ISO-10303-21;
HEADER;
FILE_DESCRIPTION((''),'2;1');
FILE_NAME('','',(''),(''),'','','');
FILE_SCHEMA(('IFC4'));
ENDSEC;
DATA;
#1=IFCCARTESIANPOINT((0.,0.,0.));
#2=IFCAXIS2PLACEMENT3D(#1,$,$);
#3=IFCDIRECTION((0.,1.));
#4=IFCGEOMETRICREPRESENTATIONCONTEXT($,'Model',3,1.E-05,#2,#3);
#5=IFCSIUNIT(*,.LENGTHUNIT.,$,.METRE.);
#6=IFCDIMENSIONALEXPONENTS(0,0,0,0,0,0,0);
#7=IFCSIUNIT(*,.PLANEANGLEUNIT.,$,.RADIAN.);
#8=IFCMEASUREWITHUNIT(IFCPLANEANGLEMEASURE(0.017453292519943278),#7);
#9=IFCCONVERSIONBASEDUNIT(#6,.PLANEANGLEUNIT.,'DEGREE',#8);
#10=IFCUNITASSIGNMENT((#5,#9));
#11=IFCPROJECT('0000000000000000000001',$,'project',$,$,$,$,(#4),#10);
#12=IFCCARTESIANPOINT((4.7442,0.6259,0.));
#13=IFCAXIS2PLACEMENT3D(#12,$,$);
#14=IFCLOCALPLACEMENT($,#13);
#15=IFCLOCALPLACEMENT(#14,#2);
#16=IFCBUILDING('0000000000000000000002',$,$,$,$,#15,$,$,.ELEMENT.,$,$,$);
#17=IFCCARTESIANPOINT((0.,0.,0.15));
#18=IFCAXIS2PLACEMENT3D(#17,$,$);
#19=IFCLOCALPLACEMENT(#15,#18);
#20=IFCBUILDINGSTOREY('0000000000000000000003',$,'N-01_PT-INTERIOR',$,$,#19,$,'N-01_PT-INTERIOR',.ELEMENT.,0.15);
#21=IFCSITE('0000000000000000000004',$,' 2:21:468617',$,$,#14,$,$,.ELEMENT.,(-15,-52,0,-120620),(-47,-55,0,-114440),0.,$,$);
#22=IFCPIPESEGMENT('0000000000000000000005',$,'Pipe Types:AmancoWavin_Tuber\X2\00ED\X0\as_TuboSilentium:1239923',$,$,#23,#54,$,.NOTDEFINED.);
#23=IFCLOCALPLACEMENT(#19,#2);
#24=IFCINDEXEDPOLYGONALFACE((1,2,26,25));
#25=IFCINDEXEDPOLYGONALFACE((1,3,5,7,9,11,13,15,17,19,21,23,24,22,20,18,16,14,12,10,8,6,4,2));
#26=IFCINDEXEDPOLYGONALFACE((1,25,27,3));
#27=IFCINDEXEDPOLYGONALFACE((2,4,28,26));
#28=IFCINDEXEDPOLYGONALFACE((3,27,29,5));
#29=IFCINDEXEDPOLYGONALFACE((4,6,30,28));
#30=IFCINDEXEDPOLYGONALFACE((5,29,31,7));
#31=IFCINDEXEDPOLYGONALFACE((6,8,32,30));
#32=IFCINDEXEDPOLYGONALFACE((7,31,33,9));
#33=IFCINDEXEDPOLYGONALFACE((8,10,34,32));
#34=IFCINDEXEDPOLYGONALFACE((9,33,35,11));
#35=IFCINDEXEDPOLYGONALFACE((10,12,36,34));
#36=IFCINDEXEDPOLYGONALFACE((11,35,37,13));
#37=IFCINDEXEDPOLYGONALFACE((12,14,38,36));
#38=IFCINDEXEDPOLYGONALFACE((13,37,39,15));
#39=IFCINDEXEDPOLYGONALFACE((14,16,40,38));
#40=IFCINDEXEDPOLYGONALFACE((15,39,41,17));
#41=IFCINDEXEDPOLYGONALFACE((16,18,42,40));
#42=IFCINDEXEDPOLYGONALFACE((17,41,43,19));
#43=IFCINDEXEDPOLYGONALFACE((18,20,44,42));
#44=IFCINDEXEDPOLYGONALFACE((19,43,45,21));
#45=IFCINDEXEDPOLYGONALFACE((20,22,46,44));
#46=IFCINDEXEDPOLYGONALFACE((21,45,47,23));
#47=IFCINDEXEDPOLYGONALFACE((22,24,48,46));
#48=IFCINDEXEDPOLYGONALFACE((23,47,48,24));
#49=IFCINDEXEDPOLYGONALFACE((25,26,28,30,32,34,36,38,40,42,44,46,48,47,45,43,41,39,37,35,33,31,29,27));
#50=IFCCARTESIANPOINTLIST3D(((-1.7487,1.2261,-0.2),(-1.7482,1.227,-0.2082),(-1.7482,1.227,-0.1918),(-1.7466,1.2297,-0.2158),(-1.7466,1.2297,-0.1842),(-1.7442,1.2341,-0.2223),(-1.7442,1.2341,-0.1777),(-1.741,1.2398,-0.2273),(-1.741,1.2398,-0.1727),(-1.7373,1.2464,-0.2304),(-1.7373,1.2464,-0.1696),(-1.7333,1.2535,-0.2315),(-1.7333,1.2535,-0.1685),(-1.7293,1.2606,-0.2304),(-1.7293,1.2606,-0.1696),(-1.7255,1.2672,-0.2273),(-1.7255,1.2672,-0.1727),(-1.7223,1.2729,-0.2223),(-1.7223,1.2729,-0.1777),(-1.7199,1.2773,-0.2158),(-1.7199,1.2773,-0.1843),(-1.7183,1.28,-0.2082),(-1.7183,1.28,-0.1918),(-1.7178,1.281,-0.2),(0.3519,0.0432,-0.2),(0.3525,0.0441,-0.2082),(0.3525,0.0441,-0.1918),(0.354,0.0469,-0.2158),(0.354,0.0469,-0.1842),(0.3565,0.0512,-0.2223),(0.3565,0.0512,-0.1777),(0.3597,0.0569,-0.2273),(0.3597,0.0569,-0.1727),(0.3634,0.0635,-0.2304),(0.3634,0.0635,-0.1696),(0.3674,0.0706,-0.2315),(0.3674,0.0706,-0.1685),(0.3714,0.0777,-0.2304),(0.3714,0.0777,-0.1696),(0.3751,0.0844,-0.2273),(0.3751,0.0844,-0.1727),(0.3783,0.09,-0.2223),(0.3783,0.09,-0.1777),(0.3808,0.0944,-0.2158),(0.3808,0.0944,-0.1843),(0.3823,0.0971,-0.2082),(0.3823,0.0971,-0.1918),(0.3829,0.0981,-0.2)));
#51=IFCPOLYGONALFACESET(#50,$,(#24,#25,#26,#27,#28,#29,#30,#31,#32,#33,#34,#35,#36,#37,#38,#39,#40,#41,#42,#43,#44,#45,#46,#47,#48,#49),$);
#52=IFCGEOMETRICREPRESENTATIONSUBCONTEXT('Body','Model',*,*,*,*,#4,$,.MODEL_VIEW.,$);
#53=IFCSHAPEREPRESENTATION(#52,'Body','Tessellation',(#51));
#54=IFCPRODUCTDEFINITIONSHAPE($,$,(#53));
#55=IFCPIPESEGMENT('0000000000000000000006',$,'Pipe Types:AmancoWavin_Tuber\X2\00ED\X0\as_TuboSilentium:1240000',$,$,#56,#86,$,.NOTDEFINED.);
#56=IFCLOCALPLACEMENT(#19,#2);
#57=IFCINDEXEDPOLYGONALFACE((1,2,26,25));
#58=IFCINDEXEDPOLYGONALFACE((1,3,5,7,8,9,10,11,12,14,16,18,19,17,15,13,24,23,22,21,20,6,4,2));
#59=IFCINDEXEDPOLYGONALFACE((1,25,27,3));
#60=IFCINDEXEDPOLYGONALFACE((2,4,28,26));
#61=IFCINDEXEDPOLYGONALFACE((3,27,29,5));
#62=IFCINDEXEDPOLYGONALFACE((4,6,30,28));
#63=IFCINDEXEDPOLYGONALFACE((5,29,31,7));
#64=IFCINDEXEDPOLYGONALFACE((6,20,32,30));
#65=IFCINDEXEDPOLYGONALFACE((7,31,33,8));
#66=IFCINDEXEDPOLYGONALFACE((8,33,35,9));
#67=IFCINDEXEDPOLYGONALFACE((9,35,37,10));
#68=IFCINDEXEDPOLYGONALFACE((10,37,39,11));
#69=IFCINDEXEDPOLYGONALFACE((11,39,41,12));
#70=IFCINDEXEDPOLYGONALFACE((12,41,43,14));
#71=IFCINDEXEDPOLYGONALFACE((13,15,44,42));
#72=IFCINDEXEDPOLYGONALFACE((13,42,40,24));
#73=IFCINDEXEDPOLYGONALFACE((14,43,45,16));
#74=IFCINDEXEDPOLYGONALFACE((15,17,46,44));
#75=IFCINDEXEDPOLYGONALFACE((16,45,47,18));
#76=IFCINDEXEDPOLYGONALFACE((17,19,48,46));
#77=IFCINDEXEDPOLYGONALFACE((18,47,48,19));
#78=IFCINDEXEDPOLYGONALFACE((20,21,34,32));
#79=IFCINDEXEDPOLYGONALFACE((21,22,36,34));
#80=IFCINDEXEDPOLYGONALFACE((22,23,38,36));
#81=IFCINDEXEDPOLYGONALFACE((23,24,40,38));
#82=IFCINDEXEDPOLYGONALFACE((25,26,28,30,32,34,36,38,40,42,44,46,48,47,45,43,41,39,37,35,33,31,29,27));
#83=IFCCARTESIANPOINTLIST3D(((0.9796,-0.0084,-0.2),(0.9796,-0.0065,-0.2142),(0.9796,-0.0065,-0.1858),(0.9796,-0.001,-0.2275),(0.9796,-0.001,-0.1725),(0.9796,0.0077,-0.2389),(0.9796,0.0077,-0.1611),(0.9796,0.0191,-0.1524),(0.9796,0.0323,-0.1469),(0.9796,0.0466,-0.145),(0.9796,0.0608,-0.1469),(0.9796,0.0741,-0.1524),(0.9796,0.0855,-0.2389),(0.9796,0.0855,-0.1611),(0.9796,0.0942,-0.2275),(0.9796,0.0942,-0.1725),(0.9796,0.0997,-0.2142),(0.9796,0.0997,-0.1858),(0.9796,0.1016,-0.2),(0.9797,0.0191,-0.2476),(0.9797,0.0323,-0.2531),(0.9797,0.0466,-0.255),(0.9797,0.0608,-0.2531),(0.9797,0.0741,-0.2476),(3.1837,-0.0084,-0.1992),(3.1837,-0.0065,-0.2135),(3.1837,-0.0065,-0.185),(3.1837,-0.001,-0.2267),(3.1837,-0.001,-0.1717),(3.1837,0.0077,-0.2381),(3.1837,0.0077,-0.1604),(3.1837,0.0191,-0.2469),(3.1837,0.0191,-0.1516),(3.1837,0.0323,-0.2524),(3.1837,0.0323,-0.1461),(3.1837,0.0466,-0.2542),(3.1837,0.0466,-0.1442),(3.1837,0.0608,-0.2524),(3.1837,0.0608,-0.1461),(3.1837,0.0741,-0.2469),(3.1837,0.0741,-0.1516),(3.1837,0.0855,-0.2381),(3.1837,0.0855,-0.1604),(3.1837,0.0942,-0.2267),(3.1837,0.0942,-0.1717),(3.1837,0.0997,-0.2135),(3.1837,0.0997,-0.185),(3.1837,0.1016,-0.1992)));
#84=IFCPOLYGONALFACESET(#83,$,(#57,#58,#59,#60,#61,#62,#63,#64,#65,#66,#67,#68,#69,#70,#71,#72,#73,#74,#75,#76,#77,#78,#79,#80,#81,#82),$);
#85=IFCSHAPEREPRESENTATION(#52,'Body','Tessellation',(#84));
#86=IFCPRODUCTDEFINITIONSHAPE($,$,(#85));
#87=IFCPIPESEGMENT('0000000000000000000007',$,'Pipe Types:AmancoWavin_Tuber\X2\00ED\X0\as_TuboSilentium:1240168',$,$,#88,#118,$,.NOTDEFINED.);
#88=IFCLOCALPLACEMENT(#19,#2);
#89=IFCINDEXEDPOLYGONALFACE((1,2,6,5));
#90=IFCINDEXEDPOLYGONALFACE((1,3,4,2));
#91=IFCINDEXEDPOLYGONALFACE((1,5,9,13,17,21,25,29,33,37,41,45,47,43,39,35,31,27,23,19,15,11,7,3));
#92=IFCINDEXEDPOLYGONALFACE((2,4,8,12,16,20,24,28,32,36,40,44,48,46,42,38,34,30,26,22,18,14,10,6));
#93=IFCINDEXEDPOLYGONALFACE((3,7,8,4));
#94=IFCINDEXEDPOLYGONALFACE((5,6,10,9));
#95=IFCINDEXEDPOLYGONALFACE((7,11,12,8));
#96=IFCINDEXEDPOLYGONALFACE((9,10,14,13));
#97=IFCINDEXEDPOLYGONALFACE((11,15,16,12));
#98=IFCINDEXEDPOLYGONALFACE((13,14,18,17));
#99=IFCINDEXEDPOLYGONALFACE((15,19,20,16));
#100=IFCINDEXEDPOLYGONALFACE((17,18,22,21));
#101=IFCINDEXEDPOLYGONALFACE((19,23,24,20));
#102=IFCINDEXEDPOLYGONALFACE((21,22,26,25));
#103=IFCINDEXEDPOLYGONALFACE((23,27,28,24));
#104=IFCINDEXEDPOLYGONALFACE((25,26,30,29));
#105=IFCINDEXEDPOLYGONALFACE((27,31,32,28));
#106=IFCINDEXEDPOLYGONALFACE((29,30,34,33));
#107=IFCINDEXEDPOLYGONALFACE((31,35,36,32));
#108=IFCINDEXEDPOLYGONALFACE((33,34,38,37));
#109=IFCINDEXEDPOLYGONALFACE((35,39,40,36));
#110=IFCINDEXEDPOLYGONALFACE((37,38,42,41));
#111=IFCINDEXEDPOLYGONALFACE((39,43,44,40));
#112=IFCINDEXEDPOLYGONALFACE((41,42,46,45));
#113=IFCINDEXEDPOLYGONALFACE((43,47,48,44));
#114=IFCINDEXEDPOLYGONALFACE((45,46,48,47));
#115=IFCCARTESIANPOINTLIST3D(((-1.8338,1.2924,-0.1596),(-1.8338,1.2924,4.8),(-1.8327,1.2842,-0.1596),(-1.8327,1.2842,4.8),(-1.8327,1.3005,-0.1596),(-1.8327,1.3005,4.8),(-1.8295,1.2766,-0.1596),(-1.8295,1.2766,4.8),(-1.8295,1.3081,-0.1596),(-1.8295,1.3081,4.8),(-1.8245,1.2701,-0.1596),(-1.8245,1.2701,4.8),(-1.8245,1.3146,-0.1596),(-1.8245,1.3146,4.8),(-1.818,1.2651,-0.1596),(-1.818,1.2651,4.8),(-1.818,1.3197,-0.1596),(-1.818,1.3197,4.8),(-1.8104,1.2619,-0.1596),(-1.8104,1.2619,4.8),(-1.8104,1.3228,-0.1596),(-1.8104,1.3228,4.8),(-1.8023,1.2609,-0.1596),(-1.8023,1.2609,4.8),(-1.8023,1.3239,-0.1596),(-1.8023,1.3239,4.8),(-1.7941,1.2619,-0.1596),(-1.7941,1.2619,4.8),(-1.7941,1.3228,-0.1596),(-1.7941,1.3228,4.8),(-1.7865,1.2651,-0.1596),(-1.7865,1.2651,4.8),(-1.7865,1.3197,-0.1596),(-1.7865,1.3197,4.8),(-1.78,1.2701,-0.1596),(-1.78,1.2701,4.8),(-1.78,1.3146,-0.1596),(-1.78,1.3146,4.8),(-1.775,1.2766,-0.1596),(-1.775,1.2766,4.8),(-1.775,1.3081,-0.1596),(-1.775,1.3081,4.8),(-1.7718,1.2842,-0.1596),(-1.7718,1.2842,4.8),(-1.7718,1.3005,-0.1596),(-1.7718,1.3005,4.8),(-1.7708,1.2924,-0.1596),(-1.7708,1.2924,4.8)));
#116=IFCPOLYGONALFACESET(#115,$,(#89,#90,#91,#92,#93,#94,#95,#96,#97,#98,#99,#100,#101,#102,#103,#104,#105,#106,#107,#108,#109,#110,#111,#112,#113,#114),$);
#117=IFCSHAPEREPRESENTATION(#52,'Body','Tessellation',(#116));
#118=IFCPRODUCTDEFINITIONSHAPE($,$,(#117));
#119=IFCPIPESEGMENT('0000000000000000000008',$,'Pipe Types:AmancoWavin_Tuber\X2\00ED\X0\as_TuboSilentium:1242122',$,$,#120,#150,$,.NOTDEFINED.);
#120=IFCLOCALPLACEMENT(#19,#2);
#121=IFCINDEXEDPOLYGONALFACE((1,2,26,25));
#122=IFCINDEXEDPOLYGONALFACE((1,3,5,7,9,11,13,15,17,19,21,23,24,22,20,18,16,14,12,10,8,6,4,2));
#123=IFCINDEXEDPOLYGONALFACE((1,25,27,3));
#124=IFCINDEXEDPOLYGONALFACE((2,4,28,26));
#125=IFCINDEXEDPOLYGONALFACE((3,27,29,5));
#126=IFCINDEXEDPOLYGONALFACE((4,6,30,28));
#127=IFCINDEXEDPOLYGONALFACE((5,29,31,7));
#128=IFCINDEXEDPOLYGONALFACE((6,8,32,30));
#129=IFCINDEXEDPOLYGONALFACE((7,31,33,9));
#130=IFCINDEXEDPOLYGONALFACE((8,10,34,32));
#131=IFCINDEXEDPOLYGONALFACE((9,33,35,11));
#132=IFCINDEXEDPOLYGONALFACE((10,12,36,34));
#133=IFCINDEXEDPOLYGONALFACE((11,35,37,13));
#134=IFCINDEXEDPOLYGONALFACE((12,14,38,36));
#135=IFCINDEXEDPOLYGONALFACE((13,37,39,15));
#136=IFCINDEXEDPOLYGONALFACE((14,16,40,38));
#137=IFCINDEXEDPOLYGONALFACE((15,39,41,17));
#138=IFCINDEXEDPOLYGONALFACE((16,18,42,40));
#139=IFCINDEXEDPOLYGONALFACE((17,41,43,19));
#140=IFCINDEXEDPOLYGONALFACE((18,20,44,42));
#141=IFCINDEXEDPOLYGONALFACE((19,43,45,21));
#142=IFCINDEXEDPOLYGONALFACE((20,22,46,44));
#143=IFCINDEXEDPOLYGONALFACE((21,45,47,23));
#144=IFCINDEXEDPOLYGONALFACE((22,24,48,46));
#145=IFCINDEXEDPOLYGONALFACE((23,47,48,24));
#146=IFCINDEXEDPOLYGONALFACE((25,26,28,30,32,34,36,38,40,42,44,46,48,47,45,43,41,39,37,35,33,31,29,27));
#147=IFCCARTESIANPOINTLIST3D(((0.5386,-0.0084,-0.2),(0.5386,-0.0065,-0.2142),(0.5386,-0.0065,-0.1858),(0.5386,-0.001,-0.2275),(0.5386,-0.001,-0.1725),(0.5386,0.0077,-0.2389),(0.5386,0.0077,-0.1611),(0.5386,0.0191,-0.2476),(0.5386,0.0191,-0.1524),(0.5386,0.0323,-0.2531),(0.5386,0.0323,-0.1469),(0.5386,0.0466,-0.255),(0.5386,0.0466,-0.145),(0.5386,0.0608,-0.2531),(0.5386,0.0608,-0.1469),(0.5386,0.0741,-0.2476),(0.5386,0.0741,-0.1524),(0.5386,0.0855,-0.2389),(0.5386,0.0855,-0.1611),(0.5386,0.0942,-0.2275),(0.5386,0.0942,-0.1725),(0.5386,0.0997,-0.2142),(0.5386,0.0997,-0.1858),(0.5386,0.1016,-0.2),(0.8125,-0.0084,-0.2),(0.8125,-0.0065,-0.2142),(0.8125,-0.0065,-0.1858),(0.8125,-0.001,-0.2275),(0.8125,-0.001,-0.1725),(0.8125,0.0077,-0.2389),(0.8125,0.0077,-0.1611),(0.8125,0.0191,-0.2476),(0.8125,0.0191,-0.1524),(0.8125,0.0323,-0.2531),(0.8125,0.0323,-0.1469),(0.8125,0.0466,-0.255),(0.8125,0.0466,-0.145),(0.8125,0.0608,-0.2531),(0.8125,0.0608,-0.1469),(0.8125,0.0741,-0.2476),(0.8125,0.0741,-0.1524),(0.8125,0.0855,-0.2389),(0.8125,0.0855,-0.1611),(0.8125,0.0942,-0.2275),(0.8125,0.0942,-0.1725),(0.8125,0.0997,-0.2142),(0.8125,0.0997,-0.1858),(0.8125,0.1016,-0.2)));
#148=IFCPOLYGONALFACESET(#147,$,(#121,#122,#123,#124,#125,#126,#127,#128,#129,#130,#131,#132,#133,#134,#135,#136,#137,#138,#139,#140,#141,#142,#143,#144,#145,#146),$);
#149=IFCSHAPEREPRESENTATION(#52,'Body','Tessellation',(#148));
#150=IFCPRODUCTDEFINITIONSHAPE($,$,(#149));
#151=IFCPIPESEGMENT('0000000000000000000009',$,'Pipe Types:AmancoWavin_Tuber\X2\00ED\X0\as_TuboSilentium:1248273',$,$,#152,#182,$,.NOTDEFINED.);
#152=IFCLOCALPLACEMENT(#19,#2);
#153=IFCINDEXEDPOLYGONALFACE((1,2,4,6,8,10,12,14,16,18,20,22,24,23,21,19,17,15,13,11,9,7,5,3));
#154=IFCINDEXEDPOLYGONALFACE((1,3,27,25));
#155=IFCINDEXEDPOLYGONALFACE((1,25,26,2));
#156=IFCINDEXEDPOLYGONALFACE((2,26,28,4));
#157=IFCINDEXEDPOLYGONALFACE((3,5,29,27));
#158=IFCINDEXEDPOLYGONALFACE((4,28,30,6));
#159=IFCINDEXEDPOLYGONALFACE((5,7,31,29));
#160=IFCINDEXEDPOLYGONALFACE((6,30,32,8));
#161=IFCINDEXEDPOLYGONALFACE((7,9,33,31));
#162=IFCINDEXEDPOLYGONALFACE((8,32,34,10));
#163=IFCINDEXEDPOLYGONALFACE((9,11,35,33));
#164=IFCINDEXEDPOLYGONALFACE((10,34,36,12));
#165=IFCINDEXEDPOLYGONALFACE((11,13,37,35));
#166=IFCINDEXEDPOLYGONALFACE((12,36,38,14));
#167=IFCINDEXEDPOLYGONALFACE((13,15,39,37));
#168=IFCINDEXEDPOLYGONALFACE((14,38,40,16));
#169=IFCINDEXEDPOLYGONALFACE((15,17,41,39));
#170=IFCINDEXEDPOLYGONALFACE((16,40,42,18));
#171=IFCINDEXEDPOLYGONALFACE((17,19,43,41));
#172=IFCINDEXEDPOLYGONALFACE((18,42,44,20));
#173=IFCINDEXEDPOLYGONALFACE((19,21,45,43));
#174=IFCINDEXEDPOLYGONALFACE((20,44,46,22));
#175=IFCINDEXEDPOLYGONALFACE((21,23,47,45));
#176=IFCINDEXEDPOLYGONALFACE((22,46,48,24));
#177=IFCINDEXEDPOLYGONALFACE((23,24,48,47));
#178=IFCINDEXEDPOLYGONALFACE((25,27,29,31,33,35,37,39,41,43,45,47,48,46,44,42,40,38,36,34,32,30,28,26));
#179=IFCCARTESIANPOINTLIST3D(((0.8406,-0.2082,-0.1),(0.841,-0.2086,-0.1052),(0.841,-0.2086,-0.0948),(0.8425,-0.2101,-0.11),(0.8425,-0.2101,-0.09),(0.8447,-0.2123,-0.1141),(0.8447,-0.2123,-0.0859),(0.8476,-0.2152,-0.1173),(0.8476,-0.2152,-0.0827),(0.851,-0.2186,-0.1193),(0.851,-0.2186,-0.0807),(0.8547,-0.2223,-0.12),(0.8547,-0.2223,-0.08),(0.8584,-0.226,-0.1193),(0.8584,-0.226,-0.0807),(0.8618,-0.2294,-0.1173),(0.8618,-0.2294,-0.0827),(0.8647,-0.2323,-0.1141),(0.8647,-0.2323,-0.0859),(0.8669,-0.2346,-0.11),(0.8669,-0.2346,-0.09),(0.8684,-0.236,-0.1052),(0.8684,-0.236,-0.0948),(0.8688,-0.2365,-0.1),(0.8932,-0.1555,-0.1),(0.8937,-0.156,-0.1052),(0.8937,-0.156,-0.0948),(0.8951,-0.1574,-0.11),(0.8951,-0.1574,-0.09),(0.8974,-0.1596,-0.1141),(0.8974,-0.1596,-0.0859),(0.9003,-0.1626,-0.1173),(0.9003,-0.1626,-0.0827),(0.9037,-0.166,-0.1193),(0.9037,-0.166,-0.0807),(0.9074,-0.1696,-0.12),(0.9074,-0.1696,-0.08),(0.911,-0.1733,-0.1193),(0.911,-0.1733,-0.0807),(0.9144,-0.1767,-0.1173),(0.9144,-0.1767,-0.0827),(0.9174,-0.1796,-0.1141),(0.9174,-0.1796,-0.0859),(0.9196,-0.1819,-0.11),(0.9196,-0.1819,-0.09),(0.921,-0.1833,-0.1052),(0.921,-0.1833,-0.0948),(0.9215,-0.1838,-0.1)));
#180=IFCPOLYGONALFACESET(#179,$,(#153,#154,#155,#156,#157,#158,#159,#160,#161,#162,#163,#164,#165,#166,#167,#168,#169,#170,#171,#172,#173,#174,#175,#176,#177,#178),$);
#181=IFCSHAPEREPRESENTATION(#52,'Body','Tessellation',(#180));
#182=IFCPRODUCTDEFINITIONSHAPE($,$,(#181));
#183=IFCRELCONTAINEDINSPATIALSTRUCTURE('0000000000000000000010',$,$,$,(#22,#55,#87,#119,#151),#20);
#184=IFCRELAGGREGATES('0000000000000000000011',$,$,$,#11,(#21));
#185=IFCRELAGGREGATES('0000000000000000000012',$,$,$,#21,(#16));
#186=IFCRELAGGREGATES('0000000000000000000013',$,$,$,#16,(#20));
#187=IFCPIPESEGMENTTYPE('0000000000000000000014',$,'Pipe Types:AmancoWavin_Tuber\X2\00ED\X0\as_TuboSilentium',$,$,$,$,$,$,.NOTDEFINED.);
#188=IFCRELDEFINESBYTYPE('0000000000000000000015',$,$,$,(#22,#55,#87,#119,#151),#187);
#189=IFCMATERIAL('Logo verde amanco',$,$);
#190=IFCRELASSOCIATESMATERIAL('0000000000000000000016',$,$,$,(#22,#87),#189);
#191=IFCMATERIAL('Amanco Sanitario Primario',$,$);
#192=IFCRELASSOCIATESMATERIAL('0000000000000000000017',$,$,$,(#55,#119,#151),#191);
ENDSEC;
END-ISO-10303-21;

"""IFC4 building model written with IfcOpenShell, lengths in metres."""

from ifc_helpers import new_model, entity, si_unit, converted_unit, direction, frame, origin, place, context, subcontext, project, spatial, arc, indexed_curve, outline, extrude, material, type_object, element, save


model = new_model("IFC4")

# Units and contexts
model_context = context("Model", 3, precision=1e-05, world=origin(), true_north=direction((0.0, 1.0)))
body_context = subcontext(model_context, "Body", "Model", "MODEL_VIEW")
ifc_project = project(units=[si_unit("LENGTHUNIT", "METRE"), converted_unit("PLANEANGLEUNIT", "DEGREE", entity("IfcPlaneAngleMeasure", 0.017453292519943278), si_unit("PLANEANGLEUNIT", "RADIAN"), dimensions=[0, 0, 0, 0, 0, 0, 0])], contexts=[model_context])

# Site, building, storey
site_placement = place(None, frame((4.7442, 0.6259, 0.0)))
site = spatial("IfcSite", under=ifc_project, at=site_placement, Name=" 2:21:468617", CompositionType="ELEMENT", RefLatitude=(-15, -52, 0, -120620), RefLongitude=(-47, -55, 0, -114440), RefElevation=0.0)
building_placement = place(site_placement, origin())
building = spatial("IfcBuilding", under=site, at=building_placement, CompositionType="ELEMENT")
storey_placement = place(building_placement, frame((0.0, 0.0, 0.15)))
storey = spatial("IfcBuildingStorey", under=building, at=storey_placement, Name="N-01_PT-INTERIOR", LongName="N-01_PT-INTERIOR", CompositionType="ELEMENT", Elevation=0.15)

# Pipe segments
ifc_material_1 = material(Name="Logo verde amanco")
pipe_segment_type_1 = type_object("IfcPipeSegmentType", Name="Pipe Types:AmancoWavin_Tuberías_TuboSilentium", PredefinedType="NOTDEFINED")
pipe_segment_1_placement = place(storey_placement, origin())
element("IfcPipeSegment", 1, at=pipe_segment_1_placement, inside=storey, type_object=pipe_segment_type_1, material=ifc_material_1, Name="Pipe Types:AmancoWavin_Tuberías_TuboSilentium:1239923", PredefinedType="NOTDEFINED", context=body_context, shape_type="SweptSolid", body=[
    extrude(outline(indexed_curve([(0.0315, 0.0), (0.0223, 0.0223), (0.0, 0.0315), (-0.0223, 0.0223), (-0.0315, 0.0), (-0.0223, -0.0223), (0.0, -0.0315), (0.0223, -0.0223)], segments=[arc(1, 2, 3), arc(3, 4, 5), arc(5, 6, 7), arc(7, 8, 1)], self_intersect=False)), frame((-1.7333, 1.2535, -0.2), z_axis=(0.871352, -0.490659, 0.0), x_axis=(-0.490659, -0.871352, 0.0)), (0.0, 0.0, 1.0), 2.4108),
])
ifc_material_2 = material(Name="Amanco Sanitario Primario")
pipe_segment_2_placement = place(storey_placement, origin())
element("IfcPipeSegment", 2, at=pipe_segment_2_placement, inside=storey, type_object=pipe_segment_type_1, material=ifc_material_2, Name="Pipe Types:AmancoWavin_Tuberías_TuboSilentium:1240000", PredefinedType="NOTDEFINED", context=body_context, shape_type="SweptSolid", body=[
    extrude(outline(indexed_curve([(0.055, 0.0), (0.0389, 0.0389), (0.0, 0.055), (-0.0389, 0.0389), (-0.055, 0.0), (-0.0389, -0.0389), (0.0, -0.055), (0.0389, -0.0389)], segments=[arc(1, 2, 3), arc(3, 4, 5), arc(5, 6, 7), arc(7, 8, 1)], self_intersect=False)), frame((0.9796, 0.0466, -0.2), z_axis=(1.0, 0.0, 0.000343), x_axis=(0.0, 1.0, 0.0)), (0.0, 0.0, 1.0), 2.204),
])
pipe_segment_3_placement = place(storey_placement, origin())
element("IfcPipeSegment", 3, at=pipe_segment_3_placement, inside=storey, type_object=pipe_segment_type_1, material=ifc_material_1, Name="Pipe Types:AmancoWavin_Tuberías_TuboSilentium:1240168", PredefinedType="NOTDEFINED", context=body_context, shape_type="SweptSolid", body=[
    extrude(outline(indexed_curve([(0.0315, 0.0), (0.0223, 0.0223), (0.0, 0.0315), (-0.0223, 0.0223), (-0.0315, 0.0), (-0.0223, -0.0223), (0.0, -0.0315), (0.0223, -0.0223)], segments=[arc(1, 2, 3), arc(3, 4, 5), arc(5, 6, 7), arc(7, 8, 1)], self_intersect=False)), frame((-1.8023, 1.2924, -0.1596), z_axis=(0.0, 0.0, 1.0), x_axis=(-1.0, 0.0, 0.0)), (0.0, 0.0, 1.0), 4.9597),
])
pipe_segment_4_placement = place(storey_placement, origin())
element("IfcPipeSegment", 4, at=pipe_segment_4_placement, inside=storey, type_object=pipe_segment_type_1, material=ifc_material_2, Name="Pipe Types:AmancoWavin_Tuberías_TuboSilentium:1242122", PredefinedType="NOTDEFINED", context=body_context, shape_type="SweptSolid", body=[
    extrude(outline(indexed_curve([(0.055, 0.0), (0.0389, 0.0389), (0.0, 0.055), (-0.0389, 0.0389), (-0.055, 0.0), (-0.0389, -0.0389), (0.0, -0.055), (0.0389, -0.0389)], segments=[arc(1, 2, 3), arc(3, 4, 5), arc(5, 6, 7), arc(7, 8, 1)], self_intersect=False)), frame((0.5386, 0.0466, -0.2), z_axis=(1.0, 0.0, 0.0), x_axis=(0.0, -1.0, 0.0)), (0.0, 0.0, 1.0), 0.274),
])
pipe_segment_5_placement = place(storey_placement, origin())
element("IfcPipeSegment", 5, at=pipe_segment_5_placement, inside=storey, type_object=pipe_segment_type_1, material=ifc_material_2, Name="Pipe Types:AmancoWavin_Tuberías_TuboSilentium:1248273", PredefinedType="NOTDEFINED", context=body_context, shape_type="SweptSolid", body=[
    extrude(outline(indexed_curve([(0.02, 0.0), (0.0141, 0.0141), (0.0, 0.02), (-0.0141, 0.0141), (-0.02, 0.0), (-0.0141, -0.0141), (0.0, -0.02), (0.0141, -0.0141)], segments=[arc(1, 2, 3), arc(3, 4, 5), arc(5, 6, 7), arc(7, 8, 1)], self_intersect=False)), frame((0.8547, -0.2223, -0.1), z_axis=(0.707107, 0.707107, 0.0), x_axis=(0.707107, -0.707107, 0.0)), (0.0, 0.0, 1.0), 0.0745),
])

save(model, "model.ifc")
